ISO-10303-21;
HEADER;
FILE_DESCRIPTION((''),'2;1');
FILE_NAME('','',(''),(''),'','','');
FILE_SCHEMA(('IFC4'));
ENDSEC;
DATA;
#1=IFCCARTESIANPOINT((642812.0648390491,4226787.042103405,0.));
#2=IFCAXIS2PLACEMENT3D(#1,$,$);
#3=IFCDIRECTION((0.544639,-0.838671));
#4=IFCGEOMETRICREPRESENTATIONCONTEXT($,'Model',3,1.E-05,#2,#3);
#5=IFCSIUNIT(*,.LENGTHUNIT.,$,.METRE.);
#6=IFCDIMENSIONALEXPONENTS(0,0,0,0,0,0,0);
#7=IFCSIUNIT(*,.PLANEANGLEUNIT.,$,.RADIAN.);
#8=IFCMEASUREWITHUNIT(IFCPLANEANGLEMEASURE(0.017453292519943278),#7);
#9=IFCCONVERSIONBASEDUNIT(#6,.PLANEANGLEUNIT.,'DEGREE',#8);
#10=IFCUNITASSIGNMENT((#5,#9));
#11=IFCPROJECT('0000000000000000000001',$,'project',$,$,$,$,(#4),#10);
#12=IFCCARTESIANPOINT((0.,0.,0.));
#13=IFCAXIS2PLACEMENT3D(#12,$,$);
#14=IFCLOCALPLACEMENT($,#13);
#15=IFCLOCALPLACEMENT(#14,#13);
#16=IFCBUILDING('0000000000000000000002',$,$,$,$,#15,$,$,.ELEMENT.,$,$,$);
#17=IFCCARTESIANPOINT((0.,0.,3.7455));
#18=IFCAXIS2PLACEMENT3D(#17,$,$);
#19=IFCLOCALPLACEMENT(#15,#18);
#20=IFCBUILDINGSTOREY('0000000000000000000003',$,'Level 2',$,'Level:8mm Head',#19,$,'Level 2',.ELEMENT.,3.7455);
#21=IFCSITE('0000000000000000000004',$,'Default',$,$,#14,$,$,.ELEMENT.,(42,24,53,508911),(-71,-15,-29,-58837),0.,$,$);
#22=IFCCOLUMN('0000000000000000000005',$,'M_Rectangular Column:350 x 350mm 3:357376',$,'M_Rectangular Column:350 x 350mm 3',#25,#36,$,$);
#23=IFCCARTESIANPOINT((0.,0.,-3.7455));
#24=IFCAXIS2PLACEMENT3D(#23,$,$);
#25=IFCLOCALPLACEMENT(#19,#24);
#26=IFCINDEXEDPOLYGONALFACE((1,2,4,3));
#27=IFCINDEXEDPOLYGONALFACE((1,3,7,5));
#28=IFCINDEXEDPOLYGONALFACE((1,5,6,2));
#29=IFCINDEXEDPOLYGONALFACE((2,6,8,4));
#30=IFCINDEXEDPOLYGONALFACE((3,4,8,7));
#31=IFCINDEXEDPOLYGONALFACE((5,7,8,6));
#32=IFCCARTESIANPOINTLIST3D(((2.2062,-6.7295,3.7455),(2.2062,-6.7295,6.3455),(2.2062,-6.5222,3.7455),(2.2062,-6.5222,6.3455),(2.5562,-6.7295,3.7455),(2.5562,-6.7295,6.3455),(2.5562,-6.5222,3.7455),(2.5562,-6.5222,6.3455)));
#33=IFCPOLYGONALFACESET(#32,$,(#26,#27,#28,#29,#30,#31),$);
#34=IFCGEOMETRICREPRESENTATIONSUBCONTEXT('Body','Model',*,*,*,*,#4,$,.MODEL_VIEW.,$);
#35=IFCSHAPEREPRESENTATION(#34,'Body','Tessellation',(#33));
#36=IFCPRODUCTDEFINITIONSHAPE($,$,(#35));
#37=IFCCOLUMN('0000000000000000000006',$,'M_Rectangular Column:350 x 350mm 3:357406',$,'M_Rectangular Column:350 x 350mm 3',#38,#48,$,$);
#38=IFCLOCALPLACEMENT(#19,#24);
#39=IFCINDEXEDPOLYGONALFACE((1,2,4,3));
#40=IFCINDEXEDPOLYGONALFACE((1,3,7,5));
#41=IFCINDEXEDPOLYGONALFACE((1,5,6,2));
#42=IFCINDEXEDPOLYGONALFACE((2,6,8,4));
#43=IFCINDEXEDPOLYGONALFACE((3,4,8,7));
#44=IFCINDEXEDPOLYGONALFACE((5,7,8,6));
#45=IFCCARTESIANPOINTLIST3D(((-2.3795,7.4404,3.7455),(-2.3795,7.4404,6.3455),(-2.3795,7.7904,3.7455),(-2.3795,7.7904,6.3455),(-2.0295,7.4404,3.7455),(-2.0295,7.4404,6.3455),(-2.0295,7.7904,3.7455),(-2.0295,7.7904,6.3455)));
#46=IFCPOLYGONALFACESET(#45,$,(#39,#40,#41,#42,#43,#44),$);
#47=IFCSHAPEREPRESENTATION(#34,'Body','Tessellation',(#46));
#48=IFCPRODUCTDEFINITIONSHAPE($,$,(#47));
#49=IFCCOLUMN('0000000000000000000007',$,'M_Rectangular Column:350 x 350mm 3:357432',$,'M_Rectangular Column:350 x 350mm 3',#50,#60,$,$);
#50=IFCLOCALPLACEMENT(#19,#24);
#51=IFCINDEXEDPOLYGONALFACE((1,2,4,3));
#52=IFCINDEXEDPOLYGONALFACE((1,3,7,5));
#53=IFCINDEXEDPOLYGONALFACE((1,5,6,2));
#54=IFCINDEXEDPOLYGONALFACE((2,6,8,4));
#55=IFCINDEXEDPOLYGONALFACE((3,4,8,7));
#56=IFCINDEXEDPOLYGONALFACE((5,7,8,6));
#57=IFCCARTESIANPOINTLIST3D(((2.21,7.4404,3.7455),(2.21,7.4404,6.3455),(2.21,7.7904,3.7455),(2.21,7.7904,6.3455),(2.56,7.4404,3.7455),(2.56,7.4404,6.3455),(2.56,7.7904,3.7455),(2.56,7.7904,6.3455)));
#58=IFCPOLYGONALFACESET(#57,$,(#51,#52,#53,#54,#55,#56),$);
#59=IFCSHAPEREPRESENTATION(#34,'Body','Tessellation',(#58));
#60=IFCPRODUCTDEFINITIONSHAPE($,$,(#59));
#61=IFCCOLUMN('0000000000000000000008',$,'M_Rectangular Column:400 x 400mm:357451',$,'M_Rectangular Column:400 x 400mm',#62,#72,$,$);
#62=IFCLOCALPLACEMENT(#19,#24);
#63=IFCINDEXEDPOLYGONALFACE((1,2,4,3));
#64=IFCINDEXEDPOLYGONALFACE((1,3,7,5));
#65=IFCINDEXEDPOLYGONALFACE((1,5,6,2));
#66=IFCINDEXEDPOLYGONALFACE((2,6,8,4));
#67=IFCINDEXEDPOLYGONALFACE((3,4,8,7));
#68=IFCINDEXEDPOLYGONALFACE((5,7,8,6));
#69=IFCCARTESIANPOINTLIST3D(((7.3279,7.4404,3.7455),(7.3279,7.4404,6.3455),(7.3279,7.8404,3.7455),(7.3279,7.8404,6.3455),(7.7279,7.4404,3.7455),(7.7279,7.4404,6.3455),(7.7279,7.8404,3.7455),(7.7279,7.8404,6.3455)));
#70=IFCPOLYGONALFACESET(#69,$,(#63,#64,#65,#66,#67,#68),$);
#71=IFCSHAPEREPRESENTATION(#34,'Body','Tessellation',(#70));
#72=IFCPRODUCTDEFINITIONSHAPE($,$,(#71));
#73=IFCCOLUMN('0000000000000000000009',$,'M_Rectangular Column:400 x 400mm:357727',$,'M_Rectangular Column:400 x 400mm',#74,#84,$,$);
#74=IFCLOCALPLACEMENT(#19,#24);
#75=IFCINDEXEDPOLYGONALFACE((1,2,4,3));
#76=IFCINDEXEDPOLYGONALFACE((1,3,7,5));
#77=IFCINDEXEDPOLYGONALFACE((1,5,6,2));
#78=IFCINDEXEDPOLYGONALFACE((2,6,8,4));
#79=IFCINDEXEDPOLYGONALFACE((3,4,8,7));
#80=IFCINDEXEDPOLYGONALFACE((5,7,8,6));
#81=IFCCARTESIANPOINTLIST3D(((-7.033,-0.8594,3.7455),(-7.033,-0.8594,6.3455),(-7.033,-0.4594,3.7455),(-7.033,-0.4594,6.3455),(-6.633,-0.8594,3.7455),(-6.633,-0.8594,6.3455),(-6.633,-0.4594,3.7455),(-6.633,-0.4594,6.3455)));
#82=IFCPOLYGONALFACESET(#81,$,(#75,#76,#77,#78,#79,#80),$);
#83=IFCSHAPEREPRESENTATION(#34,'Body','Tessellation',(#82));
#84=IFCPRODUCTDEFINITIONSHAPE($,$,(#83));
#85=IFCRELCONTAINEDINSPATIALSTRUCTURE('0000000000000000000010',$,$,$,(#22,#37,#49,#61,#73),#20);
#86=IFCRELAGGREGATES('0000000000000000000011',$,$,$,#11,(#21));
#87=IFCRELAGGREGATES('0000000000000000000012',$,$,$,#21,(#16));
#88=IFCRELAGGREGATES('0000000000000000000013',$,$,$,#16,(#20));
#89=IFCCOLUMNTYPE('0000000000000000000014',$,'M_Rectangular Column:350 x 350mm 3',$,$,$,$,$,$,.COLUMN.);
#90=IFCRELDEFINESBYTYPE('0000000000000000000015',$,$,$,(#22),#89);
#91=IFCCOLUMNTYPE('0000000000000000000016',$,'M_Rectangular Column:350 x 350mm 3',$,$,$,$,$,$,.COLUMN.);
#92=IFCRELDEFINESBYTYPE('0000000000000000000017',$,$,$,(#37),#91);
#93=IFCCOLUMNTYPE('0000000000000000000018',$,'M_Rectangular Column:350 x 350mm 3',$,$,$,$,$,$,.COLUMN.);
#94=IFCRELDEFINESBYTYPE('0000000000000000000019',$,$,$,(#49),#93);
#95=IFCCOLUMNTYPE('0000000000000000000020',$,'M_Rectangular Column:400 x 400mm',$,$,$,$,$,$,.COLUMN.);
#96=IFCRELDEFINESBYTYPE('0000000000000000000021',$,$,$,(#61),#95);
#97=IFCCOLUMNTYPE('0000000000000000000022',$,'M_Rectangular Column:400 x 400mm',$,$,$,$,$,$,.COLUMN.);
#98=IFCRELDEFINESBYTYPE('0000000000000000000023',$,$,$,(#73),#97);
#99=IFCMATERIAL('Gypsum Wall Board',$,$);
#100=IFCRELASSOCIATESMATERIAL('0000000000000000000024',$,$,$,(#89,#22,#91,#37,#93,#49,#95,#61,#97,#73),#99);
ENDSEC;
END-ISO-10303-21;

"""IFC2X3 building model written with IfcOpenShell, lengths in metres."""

from ifc_helpers import new_model, entity, si_unit, converted_unit, direction, frame, frame_2d, origin, origin_2d_with_axis, place, context, subcontext, project, spatial, rectangle, extrude, source, transform, mapped, material, type_object, type_shapes, element, save


model = new_model("IFC2X3")

# Units and contexts
model_context = context("Model", 3, precision=1e-05, world=frame((642812.0648390491, 4226787.042103405, 0.0)), true_north=direction((0.544639, -0.838671)))
body_context = subcontext(model_context, "Body", "Model", "MODEL_VIEW")
ifc_project = project(units=[si_unit("LENGTHUNIT", "METRE"), converted_unit("PLANEANGLEUNIT", "DEGREE", entity("IfcPlaneAngleMeasure", 0.017453292519943278), si_unit("PLANEANGLEUNIT", "RADIAN"), dimensions=[0, 0, 0, 0, 0, 0, 0])], contexts=[model_context])

# Site, building, storey
site_placement = place(None, origin())
site = spatial("IfcSite", under=ifc_project, at=site_placement, Name="Default", CompositionType="ELEMENT", RefLatitude=(42, 24, 53, 508911), RefLongitude=(-71, -15, -29, -58837), RefElevation=0.0)
building_placement = place(site_placement, origin())
building = spatial("IfcBuilding", under=site, at=building_placement, CompositionType="ELEMENT")
storey_placement = place(building_placement, frame((0.0, 0.0, 3.7455)))
storey = spatial("IfcBuildingStorey", under=building, at=storey_placement, Name="Level 2", ObjectType="Level:8mm Head", LongName="Level 2", CompositionType="ELEMENT", Elevation=3.7455)

# Columns
ifc_material_1 = material(Name="Gypsum Wall Board")
column_type_1 = type_object("IfcColumnType", Name="M_Rectangular Column:350 x 350mm 3", PredefinedType="COLUMN", material=ifc_material_1)
shared_shape_1 = source(origin(), body_context, "Body", "SweptSolid", [
    extrude(rectangle(XDim=0.2073, YDim=0.35, at=origin_2d_with_axis()), frame((2.3812, -6.6258, 3.7455), z_axis=(0.0, 0.0, 1.0), x_axis=(0.0, -1.0, 0.0)), (0.0, 0.0, 1.0), 2.6),
])
type_shapes(column_type_1, [shared_shape_1])
column_1_placement = place(storey_placement, frame((0.0, 0.0, -3.7455)))
element("IfcColumn", 1, at=column_1_placement, inside=storey, type_object=column_type_1, material=ifc_material_1, Name="M_Rectangular Column:350 x 350mm 3:357376", ObjectType="M_Rectangular Column:350 x 350mm 3", context=body_context, shape_type="MappedRepresentation", body=[
    mapped(shared_shape_1, transform((0.0, 0.0, 0.0), scale=1.0)),
])
column_type_2 = type_object("IfcColumnType", Name="M_Rectangular Column:350 x 350mm 3", PredefinedType="COLUMN", material=ifc_material_1)
shared_shape_2 = source(origin(), body_context, "Body", "SweptSolid", [
    extrude(rectangle(XDim=0.35, YDim=0.35, at=frame_2d((0.0, 0.0), x_axis=(1.0, 0.0))), frame((-2.2045, 7.6154, 3.7455), z_axis=(0.0, 0.0, 1.0), x_axis=(-1.0, 0.0, 0.0)), (0.0, 0.0, 1.0), 2.6),
])
type_shapes(column_type_2, [shared_shape_2])
column_2_placement = place(storey_placement, frame((0.0, 0.0, -3.7455)))
element("IfcColumn", 2, at=column_2_placement, inside=storey, type_object=column_type_2, material=ifc_material_1, Name="M_Rectangular Column:350 x 350mm 3:357406", ObjectType="M_Rectangular Column:350 x 350mm 3", context=body_context, shape_type="MappedRepresentation", body=[
    mapped(shared_shape_2, transform((0.0, 0.0, 0.0), scale=1.0)),
])
column_type_3 = type_object("IfcColumnType", Name="M_Rectangular Column:350 x 350mm 3", PredefinedType="COLUMN", material=ifc_material_1)
shared_shape_3 = source(origin(), body_context, "Body", "SweptSolid", [
    extrude(rectangle(XDim=0.35, YDim=0.35, at=frame_2d((0.0, 0.0), x_axis=(1.0, 0.0))), frame((2.385, 7.6154, 3.7455), z_axis=(0.0, 0.0, 1.0), x_axis=(-1.0, 0.0, 0.0)), (0.0, 0.0, 1.0), 2.6),
])
type_shapes(column_type_3, [shared_shape_3])
column_3_placement = place(storey_placement, frame((0.0, 0.0, -3.7455)))
element("IfcColumn", 3, at=column_3_placement, inside=storey, type_object=column_type_3, material=ifc_material_1, Name="M_Rectangular Column:350 x 350mm 3:357432", ObjectType="M_Rectangular Column:350 x 350mm 3", context=body_context, shape_type="MappedRepresentation", body=[
    mapped(shared_shape_3, transform((0.0, 0.0, 0.0), scale=1.0)),
])
column_type_4 = type_object("IfcColumnType", Name="M_Rectangular Column:400 x 400mm", PredefinedType="COLUMN", material=ifc_material_1)
shared_shape_4 = source(origin(), body_context, "Body", "SweptSolid", [
    extrude(rectangle(XDim=0.4, YDim=0.4, at=frame_2d((0.0, 0.0), x_axis=(1.0, 0.0))), frame((7.5279, 7.6404, 3.7455), z_axis=(0.0, 0.0, 1.0), x_axis=(-1.0, 0.0, 0.0)), (0.0, 0.0, 1.0), 2.6),
])
type_shapes(column_type_4, [shared_shape_4])
column_4_placement = place(storey_placement, frame((0.0, 0.0, -3.7455)))
element("IfcColumn", 4, at=column_4_placement, inside=storey, type_object=column_type_4, material=ifc_material_1, Name="M_Rectangular Column:400 x 400mm:357451", ObjectType="M_Rectangular Column:400 x 400mm", context=body_context, shape_type="MappedRepresentation", body=[
    mapped(shared_shape_4, transform((0.0, 0.0, 0.0), scale=1.0)),
])
column_type_5 = type_object("IfcColumnType", Name="M_Rectangular Column:400 x 400mm", PredefinedType="COLUMN", material=ifc_material_1)
shared_shape_5 = source(origin(), body_context, "Body", "SweptSolid", [
    extrude(rectangle(XDim=0.4, YDim=0.4, at=origin_2d_with_axis()), frame((-6.833, -0.6594, 3.7455), z_axis=(0.0, 0.0, 1.0), x_axis=(-1.0, 0.0, 0.0)), (0.0, 0.0, 1.0), 2.6),
])
type_shapes(column_type_5, [shared_shape_5])
column_5_placement = place(storey_placement, frame((0.0, 0.0, -3.7455)))
element("IfcColumn", 5, at=column_5_placement, inside=storey, type_object=column_type_5, material=ifc_material_1, Name="M_Rectangular Column:400 x 400mm:357727", ObjectType="M_Rectangular Column:400 x 400mm", context=body_context, shape_type="MappedRepresentation", body=[
    mapped(shared_shape_5, transform((0.0, 0.0, 0.0), scale=1.0)),
])

save(model, "model.ifc")
